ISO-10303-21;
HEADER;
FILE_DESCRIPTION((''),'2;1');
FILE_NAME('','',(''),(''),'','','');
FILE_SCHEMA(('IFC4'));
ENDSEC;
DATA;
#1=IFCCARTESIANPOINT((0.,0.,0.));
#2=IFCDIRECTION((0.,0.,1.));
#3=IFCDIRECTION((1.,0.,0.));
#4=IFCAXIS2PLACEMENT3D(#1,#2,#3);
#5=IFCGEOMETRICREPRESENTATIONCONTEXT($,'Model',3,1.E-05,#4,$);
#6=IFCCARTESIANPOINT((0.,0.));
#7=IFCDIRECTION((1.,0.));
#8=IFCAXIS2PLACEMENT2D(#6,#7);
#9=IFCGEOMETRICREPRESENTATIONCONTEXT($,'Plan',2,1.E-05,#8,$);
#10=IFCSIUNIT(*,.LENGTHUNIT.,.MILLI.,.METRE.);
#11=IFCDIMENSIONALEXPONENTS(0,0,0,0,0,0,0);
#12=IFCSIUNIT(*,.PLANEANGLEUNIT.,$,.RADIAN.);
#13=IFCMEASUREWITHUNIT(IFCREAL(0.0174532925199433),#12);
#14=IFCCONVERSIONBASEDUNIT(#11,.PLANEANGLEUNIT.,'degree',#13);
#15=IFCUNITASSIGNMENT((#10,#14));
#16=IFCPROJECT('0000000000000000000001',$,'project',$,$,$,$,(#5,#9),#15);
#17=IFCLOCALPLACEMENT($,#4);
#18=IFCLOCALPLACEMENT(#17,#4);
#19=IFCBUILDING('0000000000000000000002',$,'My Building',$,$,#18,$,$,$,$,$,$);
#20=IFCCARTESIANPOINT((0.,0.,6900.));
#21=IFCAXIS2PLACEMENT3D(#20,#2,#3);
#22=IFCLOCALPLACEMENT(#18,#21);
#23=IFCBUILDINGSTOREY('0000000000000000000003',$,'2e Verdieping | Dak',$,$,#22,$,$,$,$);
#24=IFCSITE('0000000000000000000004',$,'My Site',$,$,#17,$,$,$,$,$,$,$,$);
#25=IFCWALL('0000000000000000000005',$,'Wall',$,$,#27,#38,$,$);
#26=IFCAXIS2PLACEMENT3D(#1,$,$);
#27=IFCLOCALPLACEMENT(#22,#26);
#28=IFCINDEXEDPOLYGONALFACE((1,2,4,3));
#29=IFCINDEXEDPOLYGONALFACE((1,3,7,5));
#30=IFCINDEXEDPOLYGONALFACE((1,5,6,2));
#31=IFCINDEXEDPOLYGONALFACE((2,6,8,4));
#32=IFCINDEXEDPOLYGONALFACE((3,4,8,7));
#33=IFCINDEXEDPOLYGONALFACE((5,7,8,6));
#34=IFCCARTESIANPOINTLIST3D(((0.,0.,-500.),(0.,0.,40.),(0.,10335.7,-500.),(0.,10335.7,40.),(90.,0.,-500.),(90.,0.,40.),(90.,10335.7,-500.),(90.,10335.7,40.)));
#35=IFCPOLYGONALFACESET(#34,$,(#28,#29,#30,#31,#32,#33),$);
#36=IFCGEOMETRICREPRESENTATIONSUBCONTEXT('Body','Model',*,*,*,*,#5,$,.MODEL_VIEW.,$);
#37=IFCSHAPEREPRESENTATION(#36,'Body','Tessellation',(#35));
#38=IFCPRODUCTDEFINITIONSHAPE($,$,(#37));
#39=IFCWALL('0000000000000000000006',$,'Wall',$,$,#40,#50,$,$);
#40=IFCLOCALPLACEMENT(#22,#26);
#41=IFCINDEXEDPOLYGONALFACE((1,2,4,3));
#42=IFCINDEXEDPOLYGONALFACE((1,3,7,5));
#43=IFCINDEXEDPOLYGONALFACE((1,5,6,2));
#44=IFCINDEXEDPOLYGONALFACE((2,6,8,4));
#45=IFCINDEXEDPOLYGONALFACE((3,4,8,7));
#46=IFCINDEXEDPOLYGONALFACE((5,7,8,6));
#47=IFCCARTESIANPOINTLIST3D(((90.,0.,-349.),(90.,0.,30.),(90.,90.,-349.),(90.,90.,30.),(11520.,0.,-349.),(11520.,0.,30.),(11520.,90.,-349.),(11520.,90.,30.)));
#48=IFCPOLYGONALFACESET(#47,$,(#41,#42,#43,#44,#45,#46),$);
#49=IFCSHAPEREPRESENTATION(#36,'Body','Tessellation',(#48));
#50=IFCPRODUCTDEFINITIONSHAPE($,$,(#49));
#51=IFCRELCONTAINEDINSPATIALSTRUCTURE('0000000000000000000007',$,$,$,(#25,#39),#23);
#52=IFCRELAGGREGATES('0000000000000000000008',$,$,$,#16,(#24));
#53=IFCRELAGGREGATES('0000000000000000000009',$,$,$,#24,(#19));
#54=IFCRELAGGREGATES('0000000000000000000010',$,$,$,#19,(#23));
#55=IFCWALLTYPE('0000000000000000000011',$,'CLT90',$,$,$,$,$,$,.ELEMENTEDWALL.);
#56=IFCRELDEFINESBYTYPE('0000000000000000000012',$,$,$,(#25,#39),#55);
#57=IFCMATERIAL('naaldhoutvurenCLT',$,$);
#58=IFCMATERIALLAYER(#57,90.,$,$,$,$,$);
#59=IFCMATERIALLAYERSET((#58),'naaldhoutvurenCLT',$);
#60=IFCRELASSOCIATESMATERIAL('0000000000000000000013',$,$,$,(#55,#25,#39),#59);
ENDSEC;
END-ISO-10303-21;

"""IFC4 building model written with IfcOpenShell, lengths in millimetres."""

from ifc_helpers import new_model, entity, si_unit, converted_unit, frame, origin_with_axes, origin_2d_with_axis, place, context, subcontext, project, spatial, indexed_curve, outline, extrude, material, layer, layer_set, layer_usage, type_object, element, save


model = new_model("IFC4")

# Units and contexts
model_context = context("Model", 3, precision=1e-05, world=origin_with_axes())
plan_context = context("Plan", 2, precision=1e-05, world=origin_2d_with_axis())
body_context = subcontext(model_context, "Body", "Model", "MODEL_VIEW")
ifc_project = project(units=[si_unit("LENGTHUNIT", "METRE", prefix="MILLI"), converted_unit("PLANEANGLEUNIT", "degree", entity("IfcReal", 0.0174532925199433), si_unit("PLANEANGLEUNIT", "RADIAN"), dimensions=[0, 0, 0, 0, 0, 0, 0])], contexts=[model_context, plan_context])

# Site, building, storey
site_placement = place(None, origin_with_axes())
site = spatial("IfcSite", under=ifc_project, at=site_placement, Name="My Site")
building_placement = place(site_placement, origin_with_axes())
building = spatial("IfcBuilding", under=site, at=building_placement, Name="My Building")
storey_placement = place(building_placement, frame((0.0, 0.0, 6900.0), z_axis=(0.0, 0.0, 1.0), x_axis=(1.0, 0.0, 0.0)))
storey = spatial("IfcBuildingStorey", under=building, at=storey_placement, Name="2e Verdieping | Dak")

# Shared definitions
ifc_material_1 = material(Name="naaldhoutvurenCLT")

# Walls
ifc_layer_1 = layer(ifc_material_1, 90.0)
ifc_layer_set_1 = layer_set([ifc_layer_1], Name="naaldhoutvurenCLT")
wall_type = type_object("IfcWallType", Name="CLT90", PredefinedType="ELEMENTEDWALL", material=ifc_layer_set_1)
ifc_layer_usage_1 = layer_usage(ifc_layer_set_1, "AXIS2", "POSITIVE", 0.0)
wall_1_placement = place(storey_placement, frame((90.0, 0.0, -500.0), z_axis=(0.0, 0.0, 1.0), x_axis=(0.0, 1.0, 0.0)))
element("IfcWall", 1, at=wall_1_placement, inside=storey, type_object=wall_type, material=ifc_layer_usage_1, Name="Wall", context=body_context, shape_type="SweptSolid", body=[
    extrude(outline(indexed_curve([(0.0, 0.0), (0.0, 90.0), (10335.7, 90.0), (10335.7, 0.0), (0.0, 0.0)], self_intersect=False)), origin_with_axes(), (0.0, 0.0, 1.0), 540.0),
])
ifc_layer_usage_2 = layer_usage(ifc_layer_set_1, "AXIS2", "POSITIVE", 0.0)
wall_2_placement = place(storey_placement, frame((11520.0, 90.0, -349.0), z_axis=(0.0, 0.0, 1.0), x_axis=(-1.0, 0.000001, 0.0)))
element("IfcWall", 2, at=wall_2_placement, inside=storey, type_object=wall_type, material=ifc_layer_usage_2, Name="Wall", context=body_context, shape_type="SweptSolid", body=[
    extrude(outline(indexed_curve([(0.0, 0.0), (0.0, 90.0), (11430.0, 90.0), (11430.0, 0.0), (0.0, 0.0)], self_intersect=False)), origin_with_axes(), (0.0, 0.0, 1.0), 379.0),
])

save(model, "model.ifc")
